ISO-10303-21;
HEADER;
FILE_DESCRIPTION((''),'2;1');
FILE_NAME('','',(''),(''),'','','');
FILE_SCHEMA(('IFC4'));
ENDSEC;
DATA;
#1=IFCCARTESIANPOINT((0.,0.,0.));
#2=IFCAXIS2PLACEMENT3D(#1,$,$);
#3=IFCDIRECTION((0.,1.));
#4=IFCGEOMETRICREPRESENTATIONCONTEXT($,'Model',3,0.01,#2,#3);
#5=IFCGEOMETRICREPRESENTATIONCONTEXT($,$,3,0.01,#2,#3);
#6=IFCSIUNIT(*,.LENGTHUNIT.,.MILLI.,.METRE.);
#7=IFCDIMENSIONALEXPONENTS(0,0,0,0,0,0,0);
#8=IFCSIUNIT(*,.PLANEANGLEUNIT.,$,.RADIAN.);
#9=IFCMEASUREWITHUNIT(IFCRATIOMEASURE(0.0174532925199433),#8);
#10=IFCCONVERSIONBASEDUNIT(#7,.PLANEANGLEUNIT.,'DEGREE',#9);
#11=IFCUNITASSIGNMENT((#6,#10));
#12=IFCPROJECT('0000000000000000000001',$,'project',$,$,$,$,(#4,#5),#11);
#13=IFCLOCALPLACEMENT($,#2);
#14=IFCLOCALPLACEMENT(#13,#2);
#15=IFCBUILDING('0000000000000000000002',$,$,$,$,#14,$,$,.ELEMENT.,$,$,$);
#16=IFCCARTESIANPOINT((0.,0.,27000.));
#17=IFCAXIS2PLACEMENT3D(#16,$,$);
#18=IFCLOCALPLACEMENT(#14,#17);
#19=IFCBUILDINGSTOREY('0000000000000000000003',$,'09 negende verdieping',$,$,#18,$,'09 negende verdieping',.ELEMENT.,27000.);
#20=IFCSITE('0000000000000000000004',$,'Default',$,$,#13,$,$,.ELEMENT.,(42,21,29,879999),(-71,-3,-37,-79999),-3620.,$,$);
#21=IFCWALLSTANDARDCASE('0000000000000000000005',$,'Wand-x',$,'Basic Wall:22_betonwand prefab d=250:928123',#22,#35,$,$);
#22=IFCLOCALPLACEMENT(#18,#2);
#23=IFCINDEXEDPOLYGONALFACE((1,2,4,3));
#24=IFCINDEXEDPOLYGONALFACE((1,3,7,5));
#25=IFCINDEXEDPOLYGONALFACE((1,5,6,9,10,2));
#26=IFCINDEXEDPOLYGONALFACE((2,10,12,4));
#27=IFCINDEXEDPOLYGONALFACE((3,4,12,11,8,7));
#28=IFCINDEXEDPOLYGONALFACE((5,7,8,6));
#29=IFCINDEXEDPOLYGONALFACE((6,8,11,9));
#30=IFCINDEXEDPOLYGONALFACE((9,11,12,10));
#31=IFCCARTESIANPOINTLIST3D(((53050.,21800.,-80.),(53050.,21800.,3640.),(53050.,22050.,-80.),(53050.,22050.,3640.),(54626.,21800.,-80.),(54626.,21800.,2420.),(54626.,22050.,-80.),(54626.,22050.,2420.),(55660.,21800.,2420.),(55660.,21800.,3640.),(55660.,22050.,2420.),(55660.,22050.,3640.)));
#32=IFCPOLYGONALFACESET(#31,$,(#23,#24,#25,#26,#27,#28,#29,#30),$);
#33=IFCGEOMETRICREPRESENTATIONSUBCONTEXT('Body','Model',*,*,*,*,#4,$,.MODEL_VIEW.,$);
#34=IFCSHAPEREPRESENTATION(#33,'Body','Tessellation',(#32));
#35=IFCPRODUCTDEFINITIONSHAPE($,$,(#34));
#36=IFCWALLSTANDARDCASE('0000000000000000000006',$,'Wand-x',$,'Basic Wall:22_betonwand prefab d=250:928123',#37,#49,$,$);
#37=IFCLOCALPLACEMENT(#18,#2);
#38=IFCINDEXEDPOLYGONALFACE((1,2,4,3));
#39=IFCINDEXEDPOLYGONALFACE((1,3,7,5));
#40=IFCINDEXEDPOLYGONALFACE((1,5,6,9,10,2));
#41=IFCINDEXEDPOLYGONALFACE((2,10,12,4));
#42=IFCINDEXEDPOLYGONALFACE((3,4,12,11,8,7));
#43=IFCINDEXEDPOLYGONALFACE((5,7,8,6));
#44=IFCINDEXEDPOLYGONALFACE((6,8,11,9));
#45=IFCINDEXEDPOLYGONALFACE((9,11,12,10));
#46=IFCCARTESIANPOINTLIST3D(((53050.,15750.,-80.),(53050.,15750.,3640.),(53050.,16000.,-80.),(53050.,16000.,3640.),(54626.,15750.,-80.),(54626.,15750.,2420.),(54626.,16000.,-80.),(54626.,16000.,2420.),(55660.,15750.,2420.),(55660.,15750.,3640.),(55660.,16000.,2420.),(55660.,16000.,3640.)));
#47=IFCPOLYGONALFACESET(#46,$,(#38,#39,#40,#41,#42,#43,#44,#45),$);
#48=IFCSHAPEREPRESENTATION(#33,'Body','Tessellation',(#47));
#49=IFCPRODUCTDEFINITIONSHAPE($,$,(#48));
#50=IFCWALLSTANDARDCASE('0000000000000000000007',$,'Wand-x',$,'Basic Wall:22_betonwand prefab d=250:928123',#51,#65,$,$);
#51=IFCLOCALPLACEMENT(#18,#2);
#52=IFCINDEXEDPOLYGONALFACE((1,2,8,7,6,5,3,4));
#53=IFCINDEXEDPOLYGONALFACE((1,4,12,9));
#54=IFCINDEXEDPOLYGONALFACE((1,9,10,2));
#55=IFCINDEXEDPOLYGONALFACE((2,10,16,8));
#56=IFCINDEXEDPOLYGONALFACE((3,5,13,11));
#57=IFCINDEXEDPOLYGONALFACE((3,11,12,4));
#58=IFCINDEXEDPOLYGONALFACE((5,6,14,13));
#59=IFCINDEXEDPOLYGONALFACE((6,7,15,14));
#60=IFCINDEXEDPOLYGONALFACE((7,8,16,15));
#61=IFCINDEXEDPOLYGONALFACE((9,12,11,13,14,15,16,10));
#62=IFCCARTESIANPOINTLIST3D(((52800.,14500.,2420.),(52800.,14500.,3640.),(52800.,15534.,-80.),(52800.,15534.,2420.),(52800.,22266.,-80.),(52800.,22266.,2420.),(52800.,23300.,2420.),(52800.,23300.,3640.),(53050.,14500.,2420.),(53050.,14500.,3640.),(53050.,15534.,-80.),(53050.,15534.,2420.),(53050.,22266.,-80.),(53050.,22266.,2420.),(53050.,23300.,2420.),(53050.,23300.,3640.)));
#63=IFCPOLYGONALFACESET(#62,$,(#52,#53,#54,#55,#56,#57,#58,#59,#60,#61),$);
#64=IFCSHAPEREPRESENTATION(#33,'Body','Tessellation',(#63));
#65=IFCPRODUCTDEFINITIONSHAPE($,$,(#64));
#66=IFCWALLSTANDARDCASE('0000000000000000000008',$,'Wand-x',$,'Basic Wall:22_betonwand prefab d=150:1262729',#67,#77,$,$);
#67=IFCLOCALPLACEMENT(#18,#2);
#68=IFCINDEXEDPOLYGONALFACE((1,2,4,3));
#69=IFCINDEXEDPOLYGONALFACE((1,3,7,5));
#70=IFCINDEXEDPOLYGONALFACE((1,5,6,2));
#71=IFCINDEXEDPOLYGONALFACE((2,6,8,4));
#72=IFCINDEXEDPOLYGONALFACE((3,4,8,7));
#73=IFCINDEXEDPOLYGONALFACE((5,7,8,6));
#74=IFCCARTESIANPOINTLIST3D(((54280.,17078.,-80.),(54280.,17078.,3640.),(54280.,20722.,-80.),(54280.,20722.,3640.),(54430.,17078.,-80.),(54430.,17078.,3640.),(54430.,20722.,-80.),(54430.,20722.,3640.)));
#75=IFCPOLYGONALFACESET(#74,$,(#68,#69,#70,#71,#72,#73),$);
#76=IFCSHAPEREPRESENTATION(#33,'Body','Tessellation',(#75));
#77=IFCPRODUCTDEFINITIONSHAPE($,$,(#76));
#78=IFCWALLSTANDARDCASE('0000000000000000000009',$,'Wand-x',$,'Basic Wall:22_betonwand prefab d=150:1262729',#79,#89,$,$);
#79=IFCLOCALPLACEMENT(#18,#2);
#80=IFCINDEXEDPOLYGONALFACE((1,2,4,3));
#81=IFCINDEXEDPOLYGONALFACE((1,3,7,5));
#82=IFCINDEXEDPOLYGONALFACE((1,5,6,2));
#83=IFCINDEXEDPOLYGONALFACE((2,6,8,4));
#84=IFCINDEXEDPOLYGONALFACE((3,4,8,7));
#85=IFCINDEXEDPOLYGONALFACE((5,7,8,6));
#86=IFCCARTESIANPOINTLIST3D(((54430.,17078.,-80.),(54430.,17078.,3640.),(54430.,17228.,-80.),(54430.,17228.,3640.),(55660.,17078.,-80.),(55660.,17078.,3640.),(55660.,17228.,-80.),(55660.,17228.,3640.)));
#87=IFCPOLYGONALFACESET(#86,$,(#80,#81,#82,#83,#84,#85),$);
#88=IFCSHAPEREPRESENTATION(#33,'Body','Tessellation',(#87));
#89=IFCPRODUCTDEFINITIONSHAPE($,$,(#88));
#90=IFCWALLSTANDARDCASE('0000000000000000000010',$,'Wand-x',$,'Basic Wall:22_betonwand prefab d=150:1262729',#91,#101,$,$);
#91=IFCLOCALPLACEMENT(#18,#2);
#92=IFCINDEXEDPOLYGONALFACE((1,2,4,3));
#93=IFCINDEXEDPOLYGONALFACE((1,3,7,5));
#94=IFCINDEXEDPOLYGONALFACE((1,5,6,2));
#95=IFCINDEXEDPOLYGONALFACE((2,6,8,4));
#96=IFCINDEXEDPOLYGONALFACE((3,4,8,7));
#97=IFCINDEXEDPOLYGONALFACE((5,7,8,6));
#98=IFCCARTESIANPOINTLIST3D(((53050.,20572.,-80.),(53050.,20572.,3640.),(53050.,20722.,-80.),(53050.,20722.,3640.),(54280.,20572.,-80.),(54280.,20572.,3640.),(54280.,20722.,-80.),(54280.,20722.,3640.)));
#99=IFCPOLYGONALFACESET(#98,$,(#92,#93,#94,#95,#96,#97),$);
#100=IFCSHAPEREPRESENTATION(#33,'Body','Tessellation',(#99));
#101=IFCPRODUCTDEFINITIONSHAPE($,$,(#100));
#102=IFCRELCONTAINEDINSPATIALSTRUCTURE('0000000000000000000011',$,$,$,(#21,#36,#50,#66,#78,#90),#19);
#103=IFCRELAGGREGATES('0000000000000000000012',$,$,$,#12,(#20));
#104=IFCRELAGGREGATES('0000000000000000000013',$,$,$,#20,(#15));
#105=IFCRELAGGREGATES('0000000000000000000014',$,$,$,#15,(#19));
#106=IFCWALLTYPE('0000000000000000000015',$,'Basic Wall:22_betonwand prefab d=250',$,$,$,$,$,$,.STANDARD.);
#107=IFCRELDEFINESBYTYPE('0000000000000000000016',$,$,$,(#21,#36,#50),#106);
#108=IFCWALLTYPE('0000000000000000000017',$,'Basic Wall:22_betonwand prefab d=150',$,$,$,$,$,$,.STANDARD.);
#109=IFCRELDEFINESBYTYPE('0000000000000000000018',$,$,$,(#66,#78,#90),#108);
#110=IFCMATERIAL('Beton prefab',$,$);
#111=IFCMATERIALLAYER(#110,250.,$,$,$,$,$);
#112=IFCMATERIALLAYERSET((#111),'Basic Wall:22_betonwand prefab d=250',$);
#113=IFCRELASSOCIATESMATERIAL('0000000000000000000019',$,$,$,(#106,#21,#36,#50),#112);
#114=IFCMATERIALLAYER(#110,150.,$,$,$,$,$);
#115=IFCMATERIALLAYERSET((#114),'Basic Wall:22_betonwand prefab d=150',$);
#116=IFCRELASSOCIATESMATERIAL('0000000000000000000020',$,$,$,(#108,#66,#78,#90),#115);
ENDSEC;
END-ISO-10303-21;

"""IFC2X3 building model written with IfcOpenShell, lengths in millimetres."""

from ifc_helpers import new_model, entity, si_unit, converted_unit, direction, frame, frame_2d, origin, place, context, subcontext, project, spatial, rectangle, extrude, material, layer, layer_set, layer_usage, type_object, element, save


model = new_model("IFC2X3")

# Units and contexts
model_context = context("Model", 3, precision=0.01, world=origin(), true_north=direction((0.0, 1.0)))
context_of_model = context(None, 3, precision=0.01, world=origin(), true_north=direction((0.0, 1.0)))
body_context = subcontext(model_context, "Body", "Model", "MODEL_VIEW")
ifc_project = project(units=[si_unit("LENGTHUNIT", "METRE", prefix="MILLI"), converted_unit("PLANEANGLEUNIT", "DEGREE", entity("IfcRatioMeasure", 0.0174532925199433), si_unit("PLANEANGLEUNIT", "RADIAN"), dimensions=[0, 0, 0, 0, 0, 0, 0])], contexts=[model_context, context_of_model])

# Site, building, storey
site_placement = place(None, origin())
site = spatial("IfcSite", under=ifc_project, at=site_placement, Name="Default", CompositionType="ELEMENT", RefLatitude=(42, 21, 29, 879999), RefLongitude=(-71, -3, -37, -79999), RefElevation=-3620.0)
building_placement = place(site_placement, origin())
building = spatial("IfcBuilding", under=site, at=building_placement, CompositionType="ELEMENT")
storey_placement = place(building_placement, frame((0.0, 0.0, 27000.0)))
storey = spatial("IfcBuildingStorey", under=building, at=storey_placement, Name="09 negende verdieping", LongName="09 negende verdieping", CompositionType="ELEMENT", Elevation=27000.0)

# Shared definitions
ifc_material_1 = material(Name="Beton prefab")

# Walls, openings
ifc_layer_1 = layer(ifc_material_1, 250.0)
ifc_layer_set_1 = layer_set([ifc_layer_1], Name="Basic Wall:22_betonwand prefab d=250")
ifc_layer_usage_1 = layer_usage(ifc_layer_set_1, "AXIS2", "NEGATIVE", 125.0)
wall_type_1 = type_object("IfcWallType", Name="Basic Wall:22_betonwand prefab d=250", PredefinedType="STANDARD", material=ifc_layer_set_1)
wall_1_placement = place(storey_placement, frame((53050.0, 21925.0, -80.0)))
wall_1 = element("IfcWallStandardCase", 1, at=wall_1_placement, inside=storey, type_object=wall_type_1, material=ifc_layer_usage_1, Name="Wand-x", ObjectType="Basic Wall:22_betonwand prefab d=250:928123", context=body_context, shape_type="SweptSolid", body=[
    extrude(rectangle(XDim=2610.0, YDim=250.0, at=frame_2d((1305.0, 0.0), x_axis=(-1.0, 0.0))), origin(), (0.0, 0.0, 1.0), 3720.0),
])
opening_1_placement = place(wall_1_placement, frame((-53050.0, -21925.0, 80.0)))
element("IfcOpeningElement", 2, at=opening_1_placement, cuts=wall_1, ObjectType="Opening", context=body_context, shape_type="SweptSolid", body=[
    extrude(rectangle(XDim=2500.0, YDim=1034.0, at=frame_2d((0.0, 0.0), x_axis=(1.0, 0.0))), frame((55143.0, 21525.0, 1170.0), z_axis=(0.0, 1.0, 0.0), x_axis=(0.0, 0.0, -1.0)), (0.0, 0.0, 1.0), 800.0),
])
ifc_layer_usage_2 = layer_usage(ifc_layer_set_1, "AXIS2", "POSITIVE", -125.0)
wall_2_placement = place(storey_placement, frame((53050.0, 15875.0, -80.0)))
wall_2 = element("IfcWallStandardCase", 3, at=wall_2_placement, inside=storey, type_object=wall_type_1, material=ifc_layer_usage_2, Name="Wand-x", ObjectType="Basic Wall:22_betonwand prefab d=250:928123", context=body_context, shape_type="SweptSolid", body=[
    extrude(rectangle(XDim=2610.0, YDim=250.0, at=frame_2d((1305.0, 0.0), x_axis=(-1.0, 0.0))), origin(), (0.0, 0.0, 1.0), 3720.0),
])
opening_2_placement = place(wall_2_placement, frame((-53050.0, -15875.0, 80.0)))
element("IfcOpeningElement", 4, at=opening_2_placement, cuts=wall_2, ObjectType="Opening", context=body_context, shape_type="SweptSolid", body=[
    extrude(rectangle(XDim=2500.0, YDim=1034.0, at=frame_2d((0.0, 0.0), x_axis=(1.0, 0.0))), frame((55143.0, 15475.0, 1170.0), z_axis=(0.0, 1.0, 0.0), x_axis=(0.0, 0.0, -1.0)), (0.0, 0.0, 1.0), 800.0),
])

# Wall, openings
ifc_layer_usage_3 = layer_usage(ifc_layer_set_1, "AXIS2", "NEGATIVE", 125.0)
wall_3_placement = place(storey_placement, frame((52925.0, 14500.0, -80.0), z_axis=(0.0, 0.0, 1.0), x_axis=(0.0, 1.0, 0.0)))
wall_3 = element("IfcWallStandardCase", 5, at=wall_3_placement, inside=storey, type_object=wall_type_1, material=ifc_layer_usage_3, Name="Wand-x", ObjectType="Basic Wall:22_betonwand prefab d=250:928123", context=body_context, shape_type="SweptSolid", body=[
    extrude(rectangle(XDim=8800.0, YDim=250.0, at=frame_2d((4400.0, 0.0), x_axis=(-1.0, 0.0))), origin(), (0.0, 0.0, 1.0), 3720.0),
])
opening_3_placement = place(wall_3_placement, frame((-14500.0, 52925.0, 80.0), z_axis=(0.0, 0.0, 1.0), x_axis=(0.0, -1.0, 0.0)))
element("IfcOpeningElement", 6, at=opening_3_placement, cuts=wall_3, ObjectType="Opening", context=body_context, shape_type="SweptSolid", body=[
    extrude(rectangle(XDim=2500.0, YDim=1034.0, at=frame_2d((0.0, 0.0), x_axis=(1.0, 0.0))), frame((53325.0, 15017.0, 1170.0), z_axis=(-1.0, 0.0, 0.0), x_axis=(0.0, 0.0, -1.0)), (0.0, 0.0, 1.0), 800.0),
])
opening_4_placement = place(wall_3_placement, frame((-14500.0, 52925.0, 80.0), z_axis=(0.0, 0.0, 1.0), x_axis=(0.0, -1.0, 0.0)))
element("IfcOpeningElement", 7, at=opening_4_placement, cuts=wall_3, ObjectType="Opening", context=body_context, shape_type="SweptSolid", body=[
    extrude(rectangle(XDim=2500.0, YDim=1034.0, at=frame_2d((0.0, 0.0), x_axis=(0.0, 1.0))), frame((53325.0, 22783.0, 1170.0), z_axis=(-1.0, 0.0, 0.0), x_axis=(0.0, 1.0, 0.0)), (0.0, 0.0, 1.0), 800.0),
])

# Walls
ifc_layer_2 = layer(ifc_material_1, 150.0)
ifc_layer_set_2 = layer_set([ifc_layer_2], Name="Basic Wall:22_betonwand prefab d=150")
ifc_layer_usage_4 = layer_usage(ifc_layer_set_2, "AXIS2", "NEGATIVE", 75.0)
wall_type_2 = type_object("IfcWallType", Name="Basic Wall:22_betonwand prefab d=150", PredefinedType="STANDARD", material=ifc_layer_set_2)
wall_4_placement = place(storey_placement, frame((54355.0, 17078.0, -80.0), z_axis=(0.0, 0.0, 1.0), x_axis=(0.0, 1.0, 0.0)))
element("IfcWallStandardCase", 8, at=wall_4_placement, inside=storey, type_object=wall_type_2, material=ifc_layer_usage_4, Name="Wand-x", ObjectType="Basic Wall:22_betonwand prefab d=150:1262729", context=body_context, shape_type="SweptSolid", body=[
    extrude(rectangle(XDim=3644.0, YDim=150.0, at=frame_2d((1822.0, 0.0), x_axis=(-1.0, 0.0))), origin(), (0.0, 0.0, 1.0), 3720.0),
])
ifc_layer_usage_5 = layer_usage(ifc_layer_set_2, "AXIS2", "NEGATIVE", 75.0)
wall_5_placement = place(storey_placement, frame((55660.0, 17153.0, -80.0), z_axis=(0.0, 0.0, 1.0), x_axis=(-1.0, 0.0, 0.0)))
element("IfcWallStandardCase", 9, at=wall_5_placement, inside=storey, type_object=wall_type_2, material=ifc_layer_usage_5, Name="Wand-x", ObjectType="Basic Wall:22_betonwand prefab d=150:1262729", context=body_context, shape_type="SweptSolid", body=[
    extrude(rectangle(XDim=1230.0, YDim=150.0, at=frame_2d((615.0, 0.0), x_axis=(-1.0, 0.0))), origin(), (0.0, 0.0, 1.0), 3720.0),
])
ifc_layer_usage_6 = layer_usage(ifc_layer_set_2, "AXIS2", "NEGATIVE", 75.0)
wall_6_placement = place(storey_placement, frame((54280.0, 20647.0, -80.0), z_axis=(0.0, 0.0, 1.0), x_axis=(-1.0, 0.0, 0.0)))
element("IfcWallStandardCase", 10, at=wall_6_placement, inside=storey, type_object=wall_type_2, material=ifc_layer_usage_6, Name="Wand-x", ObjectType="Basic Wall:22_betonwand prefab d=150:1262729", context=body_context, shape_type="SweptSolid", body=[
    extrude(rectangle(XDim=1230.0, YDim=150.0, at=frame_2d((615.0, 0.0), x_axis=(-1.0, 0.0))), origin(), (0.0, 0.0, 1.0), 3720.0),
])

save(model, "model.ifc")
